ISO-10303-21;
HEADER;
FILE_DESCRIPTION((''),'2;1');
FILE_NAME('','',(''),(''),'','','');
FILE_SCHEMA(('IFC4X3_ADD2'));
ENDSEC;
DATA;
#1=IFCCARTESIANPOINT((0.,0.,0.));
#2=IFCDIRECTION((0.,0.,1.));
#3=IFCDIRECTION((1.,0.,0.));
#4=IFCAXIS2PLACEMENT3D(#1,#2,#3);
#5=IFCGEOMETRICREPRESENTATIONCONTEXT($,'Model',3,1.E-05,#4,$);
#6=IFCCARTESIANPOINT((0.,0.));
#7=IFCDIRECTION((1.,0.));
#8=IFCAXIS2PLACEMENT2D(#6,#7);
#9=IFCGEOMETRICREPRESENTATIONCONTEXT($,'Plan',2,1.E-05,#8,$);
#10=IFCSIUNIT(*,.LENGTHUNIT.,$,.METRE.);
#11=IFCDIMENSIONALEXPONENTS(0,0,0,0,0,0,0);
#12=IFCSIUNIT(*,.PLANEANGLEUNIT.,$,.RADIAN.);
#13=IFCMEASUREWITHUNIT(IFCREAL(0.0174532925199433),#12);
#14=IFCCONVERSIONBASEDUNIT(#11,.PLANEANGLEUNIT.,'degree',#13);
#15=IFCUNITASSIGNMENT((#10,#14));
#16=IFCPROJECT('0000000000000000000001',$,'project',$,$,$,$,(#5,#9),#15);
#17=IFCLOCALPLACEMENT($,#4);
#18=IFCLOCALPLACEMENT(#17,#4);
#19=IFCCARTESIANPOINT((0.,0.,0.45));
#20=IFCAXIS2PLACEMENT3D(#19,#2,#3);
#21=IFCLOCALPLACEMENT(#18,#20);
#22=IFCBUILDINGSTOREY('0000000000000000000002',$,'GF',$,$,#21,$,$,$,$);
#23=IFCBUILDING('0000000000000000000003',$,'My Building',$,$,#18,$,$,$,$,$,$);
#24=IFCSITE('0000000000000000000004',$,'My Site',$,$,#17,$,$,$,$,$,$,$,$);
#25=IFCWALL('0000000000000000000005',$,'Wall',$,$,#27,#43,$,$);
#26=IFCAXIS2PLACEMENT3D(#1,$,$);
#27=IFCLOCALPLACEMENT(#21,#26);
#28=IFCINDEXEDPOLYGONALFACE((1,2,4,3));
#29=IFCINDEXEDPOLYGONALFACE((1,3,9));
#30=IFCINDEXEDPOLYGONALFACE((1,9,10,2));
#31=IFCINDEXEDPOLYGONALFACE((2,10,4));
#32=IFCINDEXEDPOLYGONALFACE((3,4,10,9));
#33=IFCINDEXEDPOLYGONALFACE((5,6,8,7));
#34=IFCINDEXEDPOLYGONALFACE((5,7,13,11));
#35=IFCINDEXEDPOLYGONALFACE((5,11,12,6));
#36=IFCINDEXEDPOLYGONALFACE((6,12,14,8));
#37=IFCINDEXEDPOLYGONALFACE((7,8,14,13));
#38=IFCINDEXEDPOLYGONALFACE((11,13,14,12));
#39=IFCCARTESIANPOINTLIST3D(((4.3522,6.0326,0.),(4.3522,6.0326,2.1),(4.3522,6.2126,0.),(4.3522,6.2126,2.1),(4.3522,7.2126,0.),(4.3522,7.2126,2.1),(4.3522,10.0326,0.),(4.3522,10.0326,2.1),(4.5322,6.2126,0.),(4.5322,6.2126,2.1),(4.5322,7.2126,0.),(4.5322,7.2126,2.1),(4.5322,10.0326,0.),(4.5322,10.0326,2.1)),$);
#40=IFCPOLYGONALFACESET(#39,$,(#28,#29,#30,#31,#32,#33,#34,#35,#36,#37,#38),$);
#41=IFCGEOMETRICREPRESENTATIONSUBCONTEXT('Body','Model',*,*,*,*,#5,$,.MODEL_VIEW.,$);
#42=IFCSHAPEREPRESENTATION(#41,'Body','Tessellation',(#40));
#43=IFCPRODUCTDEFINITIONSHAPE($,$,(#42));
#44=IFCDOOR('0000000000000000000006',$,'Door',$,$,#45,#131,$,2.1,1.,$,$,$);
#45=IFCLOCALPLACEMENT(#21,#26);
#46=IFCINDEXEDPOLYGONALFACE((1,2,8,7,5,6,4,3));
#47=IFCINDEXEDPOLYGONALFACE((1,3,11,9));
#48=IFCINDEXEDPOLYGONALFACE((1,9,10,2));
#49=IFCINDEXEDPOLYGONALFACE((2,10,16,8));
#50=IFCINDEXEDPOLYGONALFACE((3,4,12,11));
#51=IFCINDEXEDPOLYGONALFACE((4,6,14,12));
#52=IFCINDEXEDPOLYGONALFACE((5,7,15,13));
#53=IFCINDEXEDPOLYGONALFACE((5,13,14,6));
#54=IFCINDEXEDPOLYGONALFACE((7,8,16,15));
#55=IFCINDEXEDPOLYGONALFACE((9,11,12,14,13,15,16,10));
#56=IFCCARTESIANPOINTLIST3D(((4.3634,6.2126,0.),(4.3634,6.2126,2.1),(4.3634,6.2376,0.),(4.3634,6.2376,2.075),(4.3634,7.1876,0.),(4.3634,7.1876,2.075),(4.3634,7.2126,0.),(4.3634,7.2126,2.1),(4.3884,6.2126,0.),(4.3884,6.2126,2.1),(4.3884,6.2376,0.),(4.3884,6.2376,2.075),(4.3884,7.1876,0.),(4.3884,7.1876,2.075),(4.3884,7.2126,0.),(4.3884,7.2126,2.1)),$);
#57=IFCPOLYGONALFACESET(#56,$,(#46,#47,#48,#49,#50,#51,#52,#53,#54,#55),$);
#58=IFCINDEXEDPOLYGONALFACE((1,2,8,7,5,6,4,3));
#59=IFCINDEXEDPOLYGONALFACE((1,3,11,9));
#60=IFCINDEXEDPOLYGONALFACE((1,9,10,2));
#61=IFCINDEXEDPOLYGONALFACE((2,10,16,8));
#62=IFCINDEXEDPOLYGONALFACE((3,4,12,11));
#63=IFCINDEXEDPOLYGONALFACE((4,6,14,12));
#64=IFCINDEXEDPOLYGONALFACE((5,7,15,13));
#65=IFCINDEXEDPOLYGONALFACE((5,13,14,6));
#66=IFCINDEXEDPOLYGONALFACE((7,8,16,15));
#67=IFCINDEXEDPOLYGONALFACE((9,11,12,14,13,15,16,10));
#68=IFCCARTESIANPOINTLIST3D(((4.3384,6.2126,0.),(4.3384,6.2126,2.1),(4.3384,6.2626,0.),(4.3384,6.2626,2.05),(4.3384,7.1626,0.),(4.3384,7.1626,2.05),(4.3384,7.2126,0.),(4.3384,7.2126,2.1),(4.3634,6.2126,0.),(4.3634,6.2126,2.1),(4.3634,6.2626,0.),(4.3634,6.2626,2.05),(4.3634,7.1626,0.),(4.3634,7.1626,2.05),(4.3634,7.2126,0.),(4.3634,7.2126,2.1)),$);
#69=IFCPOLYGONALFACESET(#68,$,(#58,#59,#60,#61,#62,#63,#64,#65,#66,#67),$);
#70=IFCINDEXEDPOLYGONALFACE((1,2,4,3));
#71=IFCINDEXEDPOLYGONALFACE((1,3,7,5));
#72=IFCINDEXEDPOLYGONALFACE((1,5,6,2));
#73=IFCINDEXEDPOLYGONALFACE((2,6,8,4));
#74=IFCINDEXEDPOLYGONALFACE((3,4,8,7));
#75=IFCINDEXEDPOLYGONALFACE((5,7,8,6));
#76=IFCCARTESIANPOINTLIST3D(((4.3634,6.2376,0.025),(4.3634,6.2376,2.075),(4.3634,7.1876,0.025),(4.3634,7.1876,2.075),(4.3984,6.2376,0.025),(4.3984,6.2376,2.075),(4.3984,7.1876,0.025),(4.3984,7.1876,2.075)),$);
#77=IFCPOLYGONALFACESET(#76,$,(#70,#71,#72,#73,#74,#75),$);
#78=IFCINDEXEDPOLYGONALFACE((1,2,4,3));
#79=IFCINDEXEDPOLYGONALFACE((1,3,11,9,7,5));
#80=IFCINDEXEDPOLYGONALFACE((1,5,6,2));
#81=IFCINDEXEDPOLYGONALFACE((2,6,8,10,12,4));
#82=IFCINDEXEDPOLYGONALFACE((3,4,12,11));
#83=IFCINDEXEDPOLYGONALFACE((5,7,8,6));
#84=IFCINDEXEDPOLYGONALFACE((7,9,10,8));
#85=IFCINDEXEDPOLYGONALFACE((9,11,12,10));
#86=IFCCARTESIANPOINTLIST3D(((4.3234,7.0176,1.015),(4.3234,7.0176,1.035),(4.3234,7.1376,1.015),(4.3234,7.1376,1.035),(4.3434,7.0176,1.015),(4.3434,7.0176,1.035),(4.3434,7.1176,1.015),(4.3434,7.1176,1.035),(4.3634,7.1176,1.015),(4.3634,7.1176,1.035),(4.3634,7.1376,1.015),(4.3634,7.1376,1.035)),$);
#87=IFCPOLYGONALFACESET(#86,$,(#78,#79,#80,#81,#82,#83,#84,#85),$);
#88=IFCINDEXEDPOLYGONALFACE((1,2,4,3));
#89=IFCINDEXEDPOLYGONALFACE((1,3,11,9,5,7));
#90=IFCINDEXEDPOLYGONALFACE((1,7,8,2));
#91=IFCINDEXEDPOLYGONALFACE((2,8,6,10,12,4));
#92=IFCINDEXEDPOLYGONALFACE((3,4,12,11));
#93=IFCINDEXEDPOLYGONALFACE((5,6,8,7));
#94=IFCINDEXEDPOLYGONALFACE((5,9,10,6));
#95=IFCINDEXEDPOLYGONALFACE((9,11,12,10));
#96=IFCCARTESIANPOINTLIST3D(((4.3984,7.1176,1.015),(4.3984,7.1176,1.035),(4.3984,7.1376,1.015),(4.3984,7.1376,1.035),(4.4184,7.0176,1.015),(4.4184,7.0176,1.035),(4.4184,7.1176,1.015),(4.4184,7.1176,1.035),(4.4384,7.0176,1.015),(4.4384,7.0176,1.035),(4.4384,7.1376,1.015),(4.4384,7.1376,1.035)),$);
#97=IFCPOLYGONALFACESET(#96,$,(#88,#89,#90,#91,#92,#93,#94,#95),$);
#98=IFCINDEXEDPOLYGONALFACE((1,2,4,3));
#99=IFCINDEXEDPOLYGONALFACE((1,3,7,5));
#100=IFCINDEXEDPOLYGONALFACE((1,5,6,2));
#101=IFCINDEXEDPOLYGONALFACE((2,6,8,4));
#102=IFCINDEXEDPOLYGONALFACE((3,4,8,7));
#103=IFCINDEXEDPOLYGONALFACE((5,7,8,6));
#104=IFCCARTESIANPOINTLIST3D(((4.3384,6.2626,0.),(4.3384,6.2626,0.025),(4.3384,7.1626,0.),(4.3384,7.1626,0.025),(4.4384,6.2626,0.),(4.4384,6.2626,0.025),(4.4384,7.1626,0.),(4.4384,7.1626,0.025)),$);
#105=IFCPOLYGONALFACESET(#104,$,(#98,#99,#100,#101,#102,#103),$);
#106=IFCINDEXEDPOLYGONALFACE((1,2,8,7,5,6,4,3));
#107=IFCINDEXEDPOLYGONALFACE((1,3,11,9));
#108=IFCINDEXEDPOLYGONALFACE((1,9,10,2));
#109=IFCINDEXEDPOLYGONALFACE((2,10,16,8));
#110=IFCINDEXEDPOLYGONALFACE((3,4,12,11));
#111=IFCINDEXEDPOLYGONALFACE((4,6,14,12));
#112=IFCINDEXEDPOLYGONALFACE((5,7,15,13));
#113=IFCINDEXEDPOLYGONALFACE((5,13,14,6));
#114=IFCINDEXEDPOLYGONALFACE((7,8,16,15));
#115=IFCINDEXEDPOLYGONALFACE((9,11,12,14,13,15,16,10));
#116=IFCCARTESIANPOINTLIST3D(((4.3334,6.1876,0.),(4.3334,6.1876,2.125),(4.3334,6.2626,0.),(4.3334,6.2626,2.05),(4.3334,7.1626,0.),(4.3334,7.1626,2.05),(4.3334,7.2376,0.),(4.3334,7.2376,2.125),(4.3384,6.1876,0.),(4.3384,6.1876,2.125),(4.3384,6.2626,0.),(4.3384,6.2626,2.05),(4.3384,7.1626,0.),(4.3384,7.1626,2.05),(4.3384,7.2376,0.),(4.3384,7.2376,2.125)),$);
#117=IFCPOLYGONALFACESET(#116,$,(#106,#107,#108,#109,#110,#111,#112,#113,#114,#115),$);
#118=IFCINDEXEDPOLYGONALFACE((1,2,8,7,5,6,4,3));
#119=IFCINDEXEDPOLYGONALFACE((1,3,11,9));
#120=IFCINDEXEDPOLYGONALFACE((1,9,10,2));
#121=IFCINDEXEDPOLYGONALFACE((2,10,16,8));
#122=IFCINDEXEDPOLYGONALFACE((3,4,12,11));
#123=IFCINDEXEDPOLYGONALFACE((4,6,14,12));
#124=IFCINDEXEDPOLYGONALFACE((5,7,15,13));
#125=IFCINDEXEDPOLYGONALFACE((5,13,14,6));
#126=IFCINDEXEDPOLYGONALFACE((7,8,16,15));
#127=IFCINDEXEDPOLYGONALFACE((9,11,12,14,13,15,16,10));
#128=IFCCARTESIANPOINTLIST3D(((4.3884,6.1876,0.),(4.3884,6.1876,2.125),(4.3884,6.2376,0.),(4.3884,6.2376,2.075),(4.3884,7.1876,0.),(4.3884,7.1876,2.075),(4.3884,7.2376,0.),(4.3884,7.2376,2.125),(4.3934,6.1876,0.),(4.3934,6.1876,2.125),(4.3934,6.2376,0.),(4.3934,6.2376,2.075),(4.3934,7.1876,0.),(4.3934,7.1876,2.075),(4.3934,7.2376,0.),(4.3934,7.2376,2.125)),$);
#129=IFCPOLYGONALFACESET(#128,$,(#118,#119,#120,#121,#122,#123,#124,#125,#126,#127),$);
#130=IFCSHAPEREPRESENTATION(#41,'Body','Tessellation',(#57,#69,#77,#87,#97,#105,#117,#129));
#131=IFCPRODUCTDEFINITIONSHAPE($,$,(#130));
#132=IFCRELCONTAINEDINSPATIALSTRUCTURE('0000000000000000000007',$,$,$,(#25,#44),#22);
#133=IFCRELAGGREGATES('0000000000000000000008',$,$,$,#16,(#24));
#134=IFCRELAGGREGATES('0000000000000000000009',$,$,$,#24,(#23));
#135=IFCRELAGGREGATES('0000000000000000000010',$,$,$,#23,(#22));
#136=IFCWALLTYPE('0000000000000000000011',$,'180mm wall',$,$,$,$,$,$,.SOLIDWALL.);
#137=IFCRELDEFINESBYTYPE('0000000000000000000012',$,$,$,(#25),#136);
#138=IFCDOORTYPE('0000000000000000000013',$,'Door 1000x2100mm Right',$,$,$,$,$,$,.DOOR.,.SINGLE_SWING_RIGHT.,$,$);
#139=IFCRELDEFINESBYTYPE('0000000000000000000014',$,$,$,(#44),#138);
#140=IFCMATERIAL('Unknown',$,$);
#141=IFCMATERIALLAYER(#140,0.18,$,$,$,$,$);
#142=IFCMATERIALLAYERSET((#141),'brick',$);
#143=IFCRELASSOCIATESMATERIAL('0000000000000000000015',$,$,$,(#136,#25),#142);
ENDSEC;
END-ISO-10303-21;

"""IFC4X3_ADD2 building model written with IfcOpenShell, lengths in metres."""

from ifc_helpers import new_model, entity, si_unit, converted_unit, frame, origin_with_axes, origin_2d_with_axis, place, context, subcontext, project, spatial, line, indexed_curve, outline, extrude, shape, source, transform, mapped, material, layer, layer_set, layer_usage, type_object, type_shapes, element, fill, save


model = new_model("IFC4X3_ADD2")

# Units and contexts
model_context = context("Model", 3, precision=1e-05, world=origin_with_axes())
plan_context = context("Plan", 2, precision=1e-05, world=origin_2d_with_axis())
body_context_1 = subcontext(model_context, "Body", "Model", "MODEL_VIEW")
body_context_2 = subcontext(plan_context, "Body", "Plan", "PLAN_VIEW")
ifc_project = project(units=[si_unit("LENGTHUNIT", "METRE"), converted_unit("PLANEANGLEUNIT", "degree", entity("IfcReal", 0.0174532925199433), si_unit("PLANEANGLEUNIT", "RADIAN"), dimensions=[0, 0, 0, 0, 0, 0, 0])], contexts=[model_context, plan_context])

# Site, building, storey
site_placement = place(None, origin_with_axes())
site = spatial("IfcSite", under=ifc_project, at=site_placement, Name="My Site")
building_placement = place(site_placement, origin_with_axes())
building = spatial("IfcBuilding", under=site, at=building_placement, Name="My Building")
storey_placement = place(building_placement, frame((0.0, 0.0, 0.45), z_axis=(0.0, 0.0, 1.0), x_axis=(1.0, 0.0, 0.0)))
storey = spatial("IfcBuildingStorey", under=building, at=storey_placement, Name="GF")

# Shared definitions
ifc_material_1 = material(Name="Unknown")

# Shared definitions
ifc_layer_1 = layer(ifc_material_1, 0.18)
ifc_layer_set_1 = layer_set([ifc_layer_1], Name="brick")
wall_type_1 = type_object("IfcWallType", Name="180mm wall", PredefinedType="SOLIDWALL", material=ifc_layer_set_1)

# Wall, opening, door
ifc_layer_usage_1 = layer_usage(ifc_layer_set_1, "AXIS2", "POSITIVE", 0.0)
wall_1_placement = place(storey_placement, frame((4.5322, 6.2126, 0.0), z_axis=(0.0, 0.0, 1.0), x_axis=(0.0, 1.0, 0.0)))
wall_1 = element("IfcWall", 1, at=wall_1_placement, inside=storey, type_object=wall_type_1, material=ifc_layer_usage_1, Name="Wall", context=body_context_1, shape_type="SweptSolid", body=[
    extrude(outline(indexed_curve([(0.0, 0.0), (-0.18, 0.18), (3.82, 0.18), (3.82, 0.0)], segments=[line(1, 2, 3, 4, 1)])), origin_with_axes(), (0.0, 0.0, 1.0), 2.1),
])
shared_shape_1 = source(origin_with_axes(), body_context_1, "Body", "SolidModel", [
    extrude(outline(indexed_curve([(0.0, 0.0), (1.0, 0.0), (1.0, 2.1), (0.0, 2.1)], segments=[line(1, 2, 3, 4, 1)])), frame((0.0, -0.6, 0.0), z_axis=(0.0, -1.0, 0.0), x_axis=(1.0, 0.0, 0.0)), (0.0, 0.0, -1.0), 1.2),
])
opening_1_placement = place(wall_1_placement, frame((1.0, 0.1938, 0.0), z_axis=(0.0, 0.0, 1.0), x_axis=(-1.0, 0.0, 0.0)))
opening_1 = element("IfcOpeningElement", 2, at=opening_1_placement, cuts=wall_1, PredefinedType="OPENING", context=body_context_1, shape_type="MappedRepresentation", body=[
    mapped(shared_shape_1, transform((0.0, 0.0, 0.0), x_axis=(1.0, 0.0, 0.0), y_axis=(0.0, 1.0, 0.0), z_axis=(0.0, 0.0, 1.0), scale=1.0)),
])
door_type = type_object("IfcDoorType", Name="Door 1000x2100mm Right", OperationType="SINGLE_SWING_RIGHT", PredefinedType="DOOR")
shared_shape_2 = source(origin_with_axes(), body_context_1, "Body", "SweptSolid", [
    extrude(outline(indexed_curve([(0.0, 0.0), (0.0, 2.1), (1.0, 2.1), (1.0, 0.0), (0.975, 0.0), (0.975, 2.075), (0.025, 2.075), (0.025, 0.0)], segments=[line(1, 2, 3, 4, 5, 6, 7, 8, 1)])), frame((0.0, 0.025, 0.0), z_axis=(0.0, -1.0, 0.0), x_axis=(1.0, 0.0, 0.0)), (0.0, 0.0, -1.0), 0.025),
    extrude(outline(indexed_curve([(0.0, 0.0), (0.0, 2.1), (1.0, 2.1), (1.0, 0.0), (0.95, 0.0), (0.95, 2.05), (0.05, 2.05), (0.05, 0.0)], segments=[line(1, 2, 3, 4, 5, 6, 7, 8, 1)])), frame((0.0, 0.0, 0.0), z_axis=(0.0, -1.0, 0.0), x_axis=(1.0, 0.0, 0.0)), (0.0, 0.0, -1.0), 0.025),
    extrude(outline(indexed_curve([(0.0, 0.0), (0.95, 0.0), (0.95, 0.035), (0.0, 0.035)], segments=[line(1, 2, 3, 4, 1)])), frame((0.025, 0.025, 0.025), z_axis=(0.0, 0.0, 1.0), x_axis=(1.0, 0.0, 0.0)), (0.0, 0.0, 1.0), 2.05),
    extrude(outline(indexed_curve([(0.0, 0.0), (0.0, -0.04), (0.12, -0.04), (0.12, -0.02), (0.02, -0.02), (0.02, 0.0)], segments=[line(1, 2, 3, 4, 5, 6, 1)])), frame((0.075, 0.025, 1.015), z_axis=(0.0, 0.0, 1.0), x_axis=(1.0, 0.0, 0.0)), (0.0, 0.0, 1.0), 0.02),
    extrude(outline(indexed_curve([(0.0, 0.0), (0.0, 0.04), (0.12, 0.04), (0.12, 0.02), (0.02, 0.02), (0.02, 0.0)], segments=[line(1, 2, 3, 4, 5, 6, 1)])), frame((0.075, 0.06, 1.015), z_axis=(0.0, 0.0, 1.0), x_axis=(1.0, 0.0, 0.0)), (0.0, 0.0, 1.0), 0.02),
    extrude(outline(indexed_curve([(0.0, 0.0), (0.9, 0.0), (0.9, 0.1), (0.0, 0.1)], segments=[line(1, 2, 3, 4, 1)])), frame((0.05, 0.0, 0.0), z_axis=(0.0, 0.0, 1.0), x_axis=(1.0, 0.0, 0.0)), (0.0, 0.0, 1.0), 0.025),
    extrude(outline(indexed_curve([(0.0, 0.0), (0.0, 2.125), (1.05, 2.125), (1.05, 0.0), (0.975, 0.0), (0.975, 2.05), (0.075, 2.05), (0.075, 0.0)], segments=[line(1, 2, 3, 4, 5, 6, 7, 8, 1)])), frame((-0.025, -0.005, 0.0), z_axis=(0.0, -1.0, 0.0), x_axis=(1.0, 0.0, 0.0)), (0.0, 0.0, -1.0), 0.005),
    extrude(outline(indexed_curve([(0.0, 0.0), (0.0, 2.125), (1.05, 2.125), (1.05, 0.0), (1.0, 0.0), (1.0, 2.075), (0.05, 2.075), (0.05, 0.0)], segments=[line(1, 2, 3, 4, 5, 6, 7, 8, 1)])), frame((-0.025, 0.05, 0.0), z_axis=(0.0, -1.0, 0.0), x_axis=(1.0, 0.0, 0.0)), (0.0, 0.0, -1.0), 0.005),
])
shared_shape_3 = source(origin_with_axes(), body_context_2, "Body", "Curve2D", [
    entity("IfcIndexedPolyCurve", entity("IfcCartesianPointList2D", [[0.0, 0.0], [0.0, 0.05], [0.025, 0.05], [0.025, 0.025], [0.05, 0.025], [0.05, 0.0]]), [entity("IfcLineIndex", [1, 2, 3, 4, 5, 6, 1])]),
    entity("IfcIndexedPolyCurve", entity("IfcCartesianPointList2D", [[1.0, 0.0], [1.0, 0.05], [0.975, 0.05], [0.975, 0.025], [0.95, 0.025], [0.95, 0.0]]), [entity("IfcLineIndex", [1, 2, 3, 4, 5, 6, 1])]),
    entity("IfcTrimmedCurve", entity("IfcEllipse", entity("IfcAxis2Placement2D", entity("IfcCartesianPoint", [0.94, 0.05]), entity("IfcDirection", [1.0, 0.0])), 0.915, 0.95), [entity("IfcCartesianPoint", [0.94, 1.0])], [entity("IfcCartesianPoint", [0.025, 0.05])], True, "CARTESIAN"),
    entity("IfcIndexedPolyCurve", entity("IfcCartesianPointList2D", [[0.975, 0.05], [0.94, 0.05], [0.94, 1.0], [0.975, 1.0]]), [entity("IfcLineIndex", [1, 2, 3, 4, 1])]),
])
type_shapes(door_type, [shared_shape_2, shared_shape_3])
door_placement = place(opening_1_placement, origin_with_axes())
door = element("IfcDoor", 3, at=door_placement, inside=storey, type_object=door_type, Name="Door", OverallHeight=2.1, OverallWidth=1.0, shapes=[
    shape(body_context_1, "Body", "MappedRepresentation", [mapped(shared_shape_2, transform((0.0, 0.0, 0.0), x_axis=(1.0, 0.0, 0.0), y_axis=(0.0, 1.0, 0.0), z_axis=(0.0, 0.0, 1.0), scale=1.0))]),
    shape(body_context_2, "Body", "MappedRepresentation", [mapped(shared_shape_3, transform((0.0, 0.0, 0.0), x_axis=(1.0, 0.0, 0.0), y_axis=(0.0, 1.0, 0.0), z_axis=(0.0, 0.0, 1.0), scale=1.0))]),
])
fill(opening_1, door)

save(model, "model.ifc")
